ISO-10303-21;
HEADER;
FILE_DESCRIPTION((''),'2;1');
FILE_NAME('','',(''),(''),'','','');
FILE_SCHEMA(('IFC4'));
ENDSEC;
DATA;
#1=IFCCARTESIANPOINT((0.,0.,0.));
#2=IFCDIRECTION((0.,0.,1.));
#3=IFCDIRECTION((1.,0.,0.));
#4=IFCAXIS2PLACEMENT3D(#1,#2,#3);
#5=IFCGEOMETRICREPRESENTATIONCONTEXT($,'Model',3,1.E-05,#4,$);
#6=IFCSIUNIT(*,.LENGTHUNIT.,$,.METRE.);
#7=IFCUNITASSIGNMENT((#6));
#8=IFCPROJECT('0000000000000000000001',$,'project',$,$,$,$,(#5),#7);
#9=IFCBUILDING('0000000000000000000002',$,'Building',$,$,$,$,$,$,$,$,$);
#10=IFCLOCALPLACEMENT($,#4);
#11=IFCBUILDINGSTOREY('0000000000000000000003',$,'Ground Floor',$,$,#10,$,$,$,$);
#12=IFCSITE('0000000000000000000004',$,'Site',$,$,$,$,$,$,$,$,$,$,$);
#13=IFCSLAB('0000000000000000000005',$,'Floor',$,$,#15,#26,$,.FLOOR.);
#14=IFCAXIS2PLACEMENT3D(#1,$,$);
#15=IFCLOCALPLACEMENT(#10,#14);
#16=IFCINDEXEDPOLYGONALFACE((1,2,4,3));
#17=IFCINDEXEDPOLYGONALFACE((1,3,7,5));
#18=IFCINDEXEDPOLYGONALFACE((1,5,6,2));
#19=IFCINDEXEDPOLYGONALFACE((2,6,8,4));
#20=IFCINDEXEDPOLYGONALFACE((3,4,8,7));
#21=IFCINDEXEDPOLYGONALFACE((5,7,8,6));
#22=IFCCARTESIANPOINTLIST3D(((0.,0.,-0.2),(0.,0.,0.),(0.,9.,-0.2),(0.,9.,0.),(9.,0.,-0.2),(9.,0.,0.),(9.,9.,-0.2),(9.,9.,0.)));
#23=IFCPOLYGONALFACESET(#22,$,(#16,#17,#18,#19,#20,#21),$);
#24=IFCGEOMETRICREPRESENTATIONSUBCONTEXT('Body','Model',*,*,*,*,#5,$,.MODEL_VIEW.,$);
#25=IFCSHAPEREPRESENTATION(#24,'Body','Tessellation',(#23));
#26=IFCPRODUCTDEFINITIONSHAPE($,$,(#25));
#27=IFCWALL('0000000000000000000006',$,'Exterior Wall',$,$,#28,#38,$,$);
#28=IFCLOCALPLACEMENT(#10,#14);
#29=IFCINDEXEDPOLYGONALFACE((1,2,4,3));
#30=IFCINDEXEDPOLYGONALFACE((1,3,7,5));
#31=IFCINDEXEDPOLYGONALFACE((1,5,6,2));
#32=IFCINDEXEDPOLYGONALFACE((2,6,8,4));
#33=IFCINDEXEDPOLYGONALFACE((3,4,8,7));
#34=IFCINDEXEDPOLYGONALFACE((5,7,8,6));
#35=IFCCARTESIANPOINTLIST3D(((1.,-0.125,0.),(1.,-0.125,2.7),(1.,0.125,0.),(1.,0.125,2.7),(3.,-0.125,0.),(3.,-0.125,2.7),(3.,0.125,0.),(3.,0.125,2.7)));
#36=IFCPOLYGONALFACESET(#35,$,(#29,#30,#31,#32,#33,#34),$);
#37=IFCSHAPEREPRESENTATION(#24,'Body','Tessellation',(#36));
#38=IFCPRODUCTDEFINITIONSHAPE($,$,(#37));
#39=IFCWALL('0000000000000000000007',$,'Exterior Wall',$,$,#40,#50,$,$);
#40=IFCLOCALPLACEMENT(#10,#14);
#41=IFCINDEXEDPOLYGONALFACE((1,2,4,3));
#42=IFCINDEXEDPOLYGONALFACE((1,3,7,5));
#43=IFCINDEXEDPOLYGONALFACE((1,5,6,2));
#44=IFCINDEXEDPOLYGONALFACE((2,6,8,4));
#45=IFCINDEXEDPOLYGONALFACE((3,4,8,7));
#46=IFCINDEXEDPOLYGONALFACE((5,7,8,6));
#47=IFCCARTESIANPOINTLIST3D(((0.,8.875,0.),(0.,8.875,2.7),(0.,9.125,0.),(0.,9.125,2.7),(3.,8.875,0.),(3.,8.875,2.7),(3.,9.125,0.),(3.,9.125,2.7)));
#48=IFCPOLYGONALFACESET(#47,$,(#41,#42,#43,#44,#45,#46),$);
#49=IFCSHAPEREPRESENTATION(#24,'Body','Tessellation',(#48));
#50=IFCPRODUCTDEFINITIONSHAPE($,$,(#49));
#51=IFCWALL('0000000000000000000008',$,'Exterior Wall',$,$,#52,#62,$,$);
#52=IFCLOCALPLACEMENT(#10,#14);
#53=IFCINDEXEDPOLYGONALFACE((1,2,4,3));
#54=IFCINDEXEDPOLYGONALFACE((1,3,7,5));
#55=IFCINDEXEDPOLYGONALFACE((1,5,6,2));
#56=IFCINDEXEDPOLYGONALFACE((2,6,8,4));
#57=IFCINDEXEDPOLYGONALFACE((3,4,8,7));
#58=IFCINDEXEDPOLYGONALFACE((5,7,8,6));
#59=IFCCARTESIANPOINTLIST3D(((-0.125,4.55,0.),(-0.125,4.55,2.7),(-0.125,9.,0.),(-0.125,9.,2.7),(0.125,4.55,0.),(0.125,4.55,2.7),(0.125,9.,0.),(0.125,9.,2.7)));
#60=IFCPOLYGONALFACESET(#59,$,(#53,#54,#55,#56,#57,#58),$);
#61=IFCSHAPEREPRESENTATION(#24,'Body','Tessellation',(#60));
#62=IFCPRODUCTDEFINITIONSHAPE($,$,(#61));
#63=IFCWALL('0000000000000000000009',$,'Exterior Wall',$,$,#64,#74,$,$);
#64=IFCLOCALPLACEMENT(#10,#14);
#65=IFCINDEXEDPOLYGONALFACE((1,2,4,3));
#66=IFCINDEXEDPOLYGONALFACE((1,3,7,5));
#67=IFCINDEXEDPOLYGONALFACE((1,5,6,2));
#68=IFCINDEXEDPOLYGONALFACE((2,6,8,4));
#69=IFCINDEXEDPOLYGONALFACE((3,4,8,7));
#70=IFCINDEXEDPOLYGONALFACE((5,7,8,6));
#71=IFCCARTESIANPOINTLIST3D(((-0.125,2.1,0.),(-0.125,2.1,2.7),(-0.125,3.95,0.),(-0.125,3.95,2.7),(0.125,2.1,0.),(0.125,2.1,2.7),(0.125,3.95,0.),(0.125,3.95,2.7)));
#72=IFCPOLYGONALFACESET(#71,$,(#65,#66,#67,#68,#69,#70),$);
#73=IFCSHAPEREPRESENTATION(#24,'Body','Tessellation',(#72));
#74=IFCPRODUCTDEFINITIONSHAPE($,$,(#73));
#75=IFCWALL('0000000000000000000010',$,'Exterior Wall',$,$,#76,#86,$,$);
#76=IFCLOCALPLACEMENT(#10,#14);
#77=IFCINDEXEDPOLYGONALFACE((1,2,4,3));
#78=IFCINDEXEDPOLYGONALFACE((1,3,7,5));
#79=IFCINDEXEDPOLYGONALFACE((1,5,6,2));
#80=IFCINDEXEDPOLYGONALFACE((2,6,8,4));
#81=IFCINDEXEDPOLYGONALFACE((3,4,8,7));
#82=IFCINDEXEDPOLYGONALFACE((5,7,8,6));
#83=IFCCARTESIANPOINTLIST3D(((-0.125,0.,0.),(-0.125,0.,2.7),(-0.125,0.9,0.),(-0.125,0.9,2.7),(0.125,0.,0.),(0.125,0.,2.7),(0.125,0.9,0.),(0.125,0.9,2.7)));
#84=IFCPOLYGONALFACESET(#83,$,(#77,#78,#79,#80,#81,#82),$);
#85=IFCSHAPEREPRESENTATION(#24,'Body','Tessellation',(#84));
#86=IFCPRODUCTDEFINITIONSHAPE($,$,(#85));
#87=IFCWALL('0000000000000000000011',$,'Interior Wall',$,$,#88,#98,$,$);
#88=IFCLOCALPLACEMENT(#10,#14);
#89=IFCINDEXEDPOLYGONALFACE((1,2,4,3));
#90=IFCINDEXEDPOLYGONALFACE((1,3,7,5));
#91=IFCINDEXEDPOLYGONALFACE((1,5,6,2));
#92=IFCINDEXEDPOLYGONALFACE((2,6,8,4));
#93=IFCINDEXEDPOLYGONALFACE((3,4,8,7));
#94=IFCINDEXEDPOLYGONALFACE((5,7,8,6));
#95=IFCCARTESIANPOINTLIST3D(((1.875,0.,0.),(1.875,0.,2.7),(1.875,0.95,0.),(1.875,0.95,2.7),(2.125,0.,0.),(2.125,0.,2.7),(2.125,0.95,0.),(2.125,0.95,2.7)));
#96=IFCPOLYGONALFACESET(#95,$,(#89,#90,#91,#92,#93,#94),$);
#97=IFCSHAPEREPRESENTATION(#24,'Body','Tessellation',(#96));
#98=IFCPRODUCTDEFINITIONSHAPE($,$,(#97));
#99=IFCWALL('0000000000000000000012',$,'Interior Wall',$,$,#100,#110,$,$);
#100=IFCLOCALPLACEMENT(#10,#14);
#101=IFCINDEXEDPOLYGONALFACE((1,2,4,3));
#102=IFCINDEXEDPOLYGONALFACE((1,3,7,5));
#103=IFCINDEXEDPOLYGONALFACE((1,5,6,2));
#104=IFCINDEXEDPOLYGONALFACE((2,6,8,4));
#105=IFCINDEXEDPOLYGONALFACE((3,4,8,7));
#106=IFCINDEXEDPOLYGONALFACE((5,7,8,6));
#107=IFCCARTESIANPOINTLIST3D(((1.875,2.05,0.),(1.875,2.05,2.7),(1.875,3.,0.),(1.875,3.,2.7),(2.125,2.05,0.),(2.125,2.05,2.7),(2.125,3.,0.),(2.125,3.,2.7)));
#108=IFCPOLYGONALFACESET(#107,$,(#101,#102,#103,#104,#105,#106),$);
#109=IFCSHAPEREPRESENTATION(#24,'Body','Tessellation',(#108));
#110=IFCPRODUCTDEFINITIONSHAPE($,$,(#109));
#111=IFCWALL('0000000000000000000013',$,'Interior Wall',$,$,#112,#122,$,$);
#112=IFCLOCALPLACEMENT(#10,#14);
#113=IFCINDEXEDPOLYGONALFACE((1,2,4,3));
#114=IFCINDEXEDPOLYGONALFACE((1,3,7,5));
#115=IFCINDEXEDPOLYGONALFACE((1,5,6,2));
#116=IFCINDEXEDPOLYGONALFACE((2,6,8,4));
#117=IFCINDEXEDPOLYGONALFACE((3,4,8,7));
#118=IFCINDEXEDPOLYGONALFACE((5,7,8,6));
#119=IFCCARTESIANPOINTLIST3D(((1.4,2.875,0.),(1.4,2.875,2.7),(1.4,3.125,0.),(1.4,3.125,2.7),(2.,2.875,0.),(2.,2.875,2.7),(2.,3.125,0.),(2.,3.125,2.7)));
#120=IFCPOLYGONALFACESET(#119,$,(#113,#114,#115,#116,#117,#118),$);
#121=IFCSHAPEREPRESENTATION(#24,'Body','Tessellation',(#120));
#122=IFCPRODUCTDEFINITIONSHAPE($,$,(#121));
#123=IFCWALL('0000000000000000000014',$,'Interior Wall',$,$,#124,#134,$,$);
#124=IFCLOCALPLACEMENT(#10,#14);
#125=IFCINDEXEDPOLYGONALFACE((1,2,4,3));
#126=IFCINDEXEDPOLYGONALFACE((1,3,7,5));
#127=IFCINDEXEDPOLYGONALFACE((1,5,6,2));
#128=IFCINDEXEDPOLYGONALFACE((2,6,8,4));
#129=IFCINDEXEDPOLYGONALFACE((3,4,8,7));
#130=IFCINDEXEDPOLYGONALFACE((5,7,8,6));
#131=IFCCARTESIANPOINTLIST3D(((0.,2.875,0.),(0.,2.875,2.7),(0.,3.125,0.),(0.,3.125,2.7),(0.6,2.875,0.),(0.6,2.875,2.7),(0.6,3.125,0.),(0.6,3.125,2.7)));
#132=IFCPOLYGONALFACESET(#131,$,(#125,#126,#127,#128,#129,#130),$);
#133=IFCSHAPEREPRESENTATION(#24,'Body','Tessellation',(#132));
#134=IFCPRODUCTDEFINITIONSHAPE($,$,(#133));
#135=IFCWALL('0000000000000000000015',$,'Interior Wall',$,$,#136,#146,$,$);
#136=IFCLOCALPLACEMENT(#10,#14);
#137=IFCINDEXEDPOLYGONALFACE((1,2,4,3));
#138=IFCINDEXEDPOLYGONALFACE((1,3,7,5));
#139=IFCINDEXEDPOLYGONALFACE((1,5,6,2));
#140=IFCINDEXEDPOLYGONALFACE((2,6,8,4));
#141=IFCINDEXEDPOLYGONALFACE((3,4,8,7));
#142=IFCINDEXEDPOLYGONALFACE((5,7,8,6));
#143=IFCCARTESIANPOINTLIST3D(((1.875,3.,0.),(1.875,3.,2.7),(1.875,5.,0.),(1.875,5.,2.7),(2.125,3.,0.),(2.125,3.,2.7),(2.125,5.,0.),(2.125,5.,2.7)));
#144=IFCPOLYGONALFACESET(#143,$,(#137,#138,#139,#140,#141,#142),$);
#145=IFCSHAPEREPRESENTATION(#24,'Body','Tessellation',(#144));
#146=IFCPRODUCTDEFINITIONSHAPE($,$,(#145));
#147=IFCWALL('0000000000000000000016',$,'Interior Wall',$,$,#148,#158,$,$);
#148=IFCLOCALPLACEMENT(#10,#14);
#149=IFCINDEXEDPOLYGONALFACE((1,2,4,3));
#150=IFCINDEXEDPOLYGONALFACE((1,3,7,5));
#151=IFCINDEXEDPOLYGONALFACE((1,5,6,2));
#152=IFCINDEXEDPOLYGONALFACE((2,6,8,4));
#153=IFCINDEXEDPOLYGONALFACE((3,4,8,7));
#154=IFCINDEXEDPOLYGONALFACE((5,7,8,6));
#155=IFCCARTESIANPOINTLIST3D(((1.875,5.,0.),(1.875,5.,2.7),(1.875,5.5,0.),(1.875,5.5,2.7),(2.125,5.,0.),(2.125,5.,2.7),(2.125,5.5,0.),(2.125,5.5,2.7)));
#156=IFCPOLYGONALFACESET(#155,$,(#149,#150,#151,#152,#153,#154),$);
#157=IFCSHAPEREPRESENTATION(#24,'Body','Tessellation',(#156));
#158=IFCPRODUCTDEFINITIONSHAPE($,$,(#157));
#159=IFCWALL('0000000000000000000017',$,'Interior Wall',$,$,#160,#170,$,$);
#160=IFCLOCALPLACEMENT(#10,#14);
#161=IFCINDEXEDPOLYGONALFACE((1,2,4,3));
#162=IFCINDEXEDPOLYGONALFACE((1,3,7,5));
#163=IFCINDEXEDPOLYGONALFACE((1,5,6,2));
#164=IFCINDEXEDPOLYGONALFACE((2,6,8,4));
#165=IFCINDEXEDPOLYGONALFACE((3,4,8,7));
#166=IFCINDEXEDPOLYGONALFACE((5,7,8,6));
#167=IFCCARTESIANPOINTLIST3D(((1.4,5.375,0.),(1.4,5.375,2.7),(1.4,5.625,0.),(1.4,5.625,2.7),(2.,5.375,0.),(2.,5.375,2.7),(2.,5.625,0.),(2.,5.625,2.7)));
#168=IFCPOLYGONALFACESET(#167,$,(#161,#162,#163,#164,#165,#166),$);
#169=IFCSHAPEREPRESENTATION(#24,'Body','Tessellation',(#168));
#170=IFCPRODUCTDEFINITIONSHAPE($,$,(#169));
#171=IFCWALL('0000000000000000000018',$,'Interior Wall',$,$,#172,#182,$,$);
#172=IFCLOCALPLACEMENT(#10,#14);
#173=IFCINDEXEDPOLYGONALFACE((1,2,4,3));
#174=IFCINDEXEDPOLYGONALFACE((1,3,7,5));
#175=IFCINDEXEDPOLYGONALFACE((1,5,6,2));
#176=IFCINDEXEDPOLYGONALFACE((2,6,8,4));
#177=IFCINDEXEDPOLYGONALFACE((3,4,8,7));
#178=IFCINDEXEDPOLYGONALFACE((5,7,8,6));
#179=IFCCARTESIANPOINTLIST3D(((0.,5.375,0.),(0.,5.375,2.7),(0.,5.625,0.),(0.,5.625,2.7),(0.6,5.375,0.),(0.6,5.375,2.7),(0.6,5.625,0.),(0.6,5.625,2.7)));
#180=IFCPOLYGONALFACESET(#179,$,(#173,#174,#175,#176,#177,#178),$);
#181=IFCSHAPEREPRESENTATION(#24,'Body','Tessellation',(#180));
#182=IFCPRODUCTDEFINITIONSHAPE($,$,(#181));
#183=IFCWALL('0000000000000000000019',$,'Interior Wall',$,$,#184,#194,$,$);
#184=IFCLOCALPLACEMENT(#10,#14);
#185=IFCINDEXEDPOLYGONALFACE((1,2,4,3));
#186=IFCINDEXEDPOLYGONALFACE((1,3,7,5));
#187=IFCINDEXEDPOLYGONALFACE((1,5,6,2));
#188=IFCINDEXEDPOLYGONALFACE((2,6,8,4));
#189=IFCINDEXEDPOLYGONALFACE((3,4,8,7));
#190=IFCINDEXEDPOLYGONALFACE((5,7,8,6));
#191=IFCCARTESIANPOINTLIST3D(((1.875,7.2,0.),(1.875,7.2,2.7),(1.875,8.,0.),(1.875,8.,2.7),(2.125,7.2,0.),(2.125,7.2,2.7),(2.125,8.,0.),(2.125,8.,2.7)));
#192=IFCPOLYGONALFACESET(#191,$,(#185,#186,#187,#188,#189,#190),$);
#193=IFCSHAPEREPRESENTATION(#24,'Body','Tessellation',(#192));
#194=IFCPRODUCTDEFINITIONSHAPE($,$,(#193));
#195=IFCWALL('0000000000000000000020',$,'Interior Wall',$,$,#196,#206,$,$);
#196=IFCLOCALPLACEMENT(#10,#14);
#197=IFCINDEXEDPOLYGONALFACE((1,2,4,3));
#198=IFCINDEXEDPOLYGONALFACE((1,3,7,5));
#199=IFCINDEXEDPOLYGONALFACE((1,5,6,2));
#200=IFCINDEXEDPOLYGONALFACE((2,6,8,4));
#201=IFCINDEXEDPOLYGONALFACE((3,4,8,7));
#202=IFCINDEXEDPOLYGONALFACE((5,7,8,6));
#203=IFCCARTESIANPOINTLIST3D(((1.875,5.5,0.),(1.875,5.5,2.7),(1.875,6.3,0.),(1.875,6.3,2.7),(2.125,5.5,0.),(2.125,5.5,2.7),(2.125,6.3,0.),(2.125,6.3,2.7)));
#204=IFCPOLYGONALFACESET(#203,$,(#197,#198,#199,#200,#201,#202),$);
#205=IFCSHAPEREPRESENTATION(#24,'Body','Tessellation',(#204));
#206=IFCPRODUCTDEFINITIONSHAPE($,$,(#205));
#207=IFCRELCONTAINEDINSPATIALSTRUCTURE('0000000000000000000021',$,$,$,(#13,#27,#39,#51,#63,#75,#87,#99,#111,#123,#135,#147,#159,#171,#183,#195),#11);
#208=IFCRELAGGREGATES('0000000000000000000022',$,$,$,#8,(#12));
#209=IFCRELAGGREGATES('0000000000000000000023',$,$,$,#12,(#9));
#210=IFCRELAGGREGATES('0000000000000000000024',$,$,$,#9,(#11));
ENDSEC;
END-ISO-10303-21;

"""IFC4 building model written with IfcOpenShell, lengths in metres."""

from ifc_helpers import new_model, si_unit, frame, origin_with_axes, place, context, subcontext, project, spatial, indexed_curve, outline, extrude, element, save


model = new_model("IFC4")

# Units and contexts
model_context = context("Model", 3, precision=1e-05, world=origin_with_axes())
body_context = subcontext(model_context, "Body", "Model", "MODEL_VIEW")
ifc_project = project(units=[si_unit("LENGTHUNIT", "METRE")], contexts=[model_context])

# Site, building, storey
site = spatial("IfcSite", under=ifc_project, Name="Site")
building = spatial("IfcBuilding", under=site, Name="Building")
storey_placement = place(None, origin_with_axes())
storey = spatial("IfcBuildingStorey", under=building, at=storey_placement, Name="Ground Floor")

# Slab
slab_placement = place(storey_placement, frame((0.0, 0.0, -0.2), z_axis=(0.0, 0.0, 1.0), x_axis=(1.0, 0.0, 0.0)))
element("IfcSlab", 1, at=slab_placement, inside=storey, Name="Floor", PredefinedType="FLOOR", context=body_context, shape_type="SweptSolid", body=[
    extrude(outline(indexed_curve([(0.0, 0.0), (9.0, 0.0), (9.0, 9.0), (0.0, 9.0)])), None, (0.0, 0.0, 1.0), 0.2),
])

# Walls
wall_1_placement = place(storey_placement, frame((1.0, 0.0, 0.0), z_axis=(0.0, 0.0, 1.0), x_axis=(1.0, 0.0, 0.0)))
element("IfcWall", 2, at=wall_1_placement, inside=storey, Name="Exterior Wall", context=body_context, shape_type="SweptSolid", body=[
    extrude(outline(indexed_curve([(0.0, 0.0), (0.0, 0.25), (2.0, 0.25), (2.0, 0.0), (0.0, 0.0)], self_intersect=False)), frame((0.0, -0.125, 0.0), z_axis=(0.0, 0.0, 1.0), x_axis=(1.0, 0.0, 0.0)), (0.0, 0.0, 1.0), 2.7),
])
wall_2_placement = place(storey_placement, frame((3.0, 9.0, 0.0), z_axis=(0.0, 0.0, 1.0), x_axis=(-1.0, 0.0, 0.0)))
element("IfcWall", 3, at=wall_2_placement, inside=storey, Name="Exterior Wall", context=body_context, shape_type="SweptSolid", body=[
    extrude(outline(indexed_curve([(0.0, 0.0), (0.0, 0.25), (3.0, 0.25), (3.0, 0.0), (0.0, 0.0)], self_intersect=False)), frame((0.0, -0.125, 0.0), z_axis=(0.0, 0.0, 1.0), x_axis=(1.0, 0.0, 0.0)), (0.0, 0.0, 1.0), 2.7),
])
wall_3_placement = place(storey_placement, frame((0.0, 9.0, 0.0), z_axis=(0.0, 0.0, 1.0), x_axis=(0.0, -1.0, 0.0)))
element("IfcWall", 4, at=wall_3_placement, inside=storey, Name="Exterior Wall", context=body_context, shape_type="SweptSolid", body=[
    extrude(outline(indexed_curve([(0.0, 0.0), (0.0, 0.25), (4.45, 0.25), (4.45, 0.0), (0.0, 0.0)], self_intersect=False)), frame((0.0, -0.125, 0.0), z_axis=(0.0, 0.0, 1.0), x_axis=(1.0, 0.0, 0.0)), (0.0, 0.0, 1.0), 2.7),
])
wall_4_placement = place(storey_placement, frame((0.0, 3.95, 0.0), z_axis=(0.0, 0.0, 1.0), x_axis=(0.0, -1.0, 0.0)))
element("IfcWall", 5, at=wall_4_placement, inside=storey, Name="Exterior Wall", context=body_context, shape_type="SweptSolid", body=[
    extrude(outline(indexed_curve([(0.0, 0.0), (0.0, 0.25), (1.85, 0.25), (1.85, 0.0), (0.0, 0.0)], self_intersect=False)), frame((0.0, -0.125, 0.0), z_axis=(0.0, 0.0, 1.0), x_axis=(1.0, 0.0, 0.0)), (0.0, 0.0, 1.0), 2.7),
])
wall_5_placement = place(storey_placement, frame((0.0, 0.9, 0.0), z_axis=(0.0, 0.0, 1.0), x_axis=(0.0, -1.0, 0.0)))
element("IfcWall", 6, at=wall_5_placement, inside=storey, Name="Exterior Wall", context=body_context, shape_type="SweptSolid", body=[
    extrude(outline(indexed_curve([(0.0, 0.0), (0.0, 0.25), (0.9, 0.25), (0.9, 0.0), (0.0, 0.0)], self_intersect=False)), frame((0.0, -0.125, 0.0), z_axis=(0.0, 0.0, 1.0), x_axis=(1.0, 0.0, 0.0)), (0.0, 0.0, 1.0), 2.7),
])
wall_6_placement = place(storey_placement, frame((2.0, 0.0, 0.0), z_axis=(0.0, 0.0, 1.0), x_axis=(0.0, 1.0, 0.0)))
element("IfcWall", 7, at=wall_6_placement, inside=storey, Name="Interior Wall", context=body_context, shape_type="SweptSolid", body=[
    extrude(outline(indexed_curve([(0.0, 0.0), (0.0, 0.25), (0.95, 0.25), (0.95, 0.0), (0.0, 0.0)], self_intersect=False)), frame((0.0, -0.125, 0.0), z_axis=(0.0, 0.0, 1.0), x_axis=(1.0, 0.0, 0.0)), (0.0, 0.0, 1.0), 2.7),
])
wall_7_placement = place(storey_placement, frame((2.0, 2.05, 0.0), z_axis=(0.0, 0.0, 1.0), x_axis=(0.0, 1.0, 0.0)))
element("IfcWall", 8, at=wall_7_placement, inside=storey, Name="Interior Wall", context=body_context, shape_type="SweptSolid", body=[
    extrude(outline(indexed_curve([(0.0, 0.0), (0.0, 0.25), (0.95, 0.25), (0.95, 0.0), (0.0, 0.0)], self_intersect=False)), frame((0.0, -0.125, 0.0), z_axis=(0.0, 0.0, 1.0), x_axis=(1.0, 0.0, 0.0)), (0.0, 0.0, 1.0), 2.7),
])
for number, where, z_axis, x_axis, name in (
    (9, (2.0, 3.0, 0.0), (0.0, 0.0, 1.0), (-1.0, 0.0, 0.0), "Interior Wall"),
    (10, (0.6, 3.0, 0.0), (0.0, 0.0, 1.0), (-1.0, 0.0, 0.0), "Interior Wall"),
):
    element("IfcWall", number, at=place(storey_placement, frame(where, z_axis=z_axis, x_axis=x_axis)), inside=storey, Name=name, context=body_context, shape_type="SweptSolid", body=[
        extrude(outline(indexed_curve([(0.0, 0.0), (0.0, 0.25), (0.6, 0.25), (0.6, 0.0), (0.0, 0.0)], self_intersect=False)), frame((0.0, -0.125, 0.0), z_axis=(0.0, 0.0, 1.0), x_axis=(1.0, 0.0, 0.0)), (0.0, 0.0, 1.0), 2.7),
    ])
wall_8_placement = place(storey_placement, frame((2.0, 5.0, 0.0), z_axis=(0.0, 0.0, 1.0), x_axis=(0.0, -1.0, 0.0)))
element("IfcWall", 11, at=wall_8_placement, inside=storey, Name="Interior Wall", context=body_context, shape_type="SweptSolid", body=[
    extrude(outline(indexed_curve([(0.0, 0.0), (0.0, 0.25), (2.0, 0.25), (2.0, 0.0), (0.0, 0.0)], self_intersect=False)), frame((0.0, -0.125, 0.0), z_axis=(0.0, 0.0, 1.0), x_axis=(1.0, 0.0, 0.0)), (0.0, 0.0, 1.0), 2.7),
])
wall_9_placement = place(storey_placement, frame((2.0, 5.0, 0.0), z_axis=(0.0, 0.0, 1.0), x_axis=(0.0, 1.0, 0.0)))
element("IfcWall", 12, at=wall_9_placement, inside=storey, Name="Interior Wall", context=body_context, shape_type="SweptSolid", body=[
    extrude(outline(indexed_curve([(0.0, 0.0), (0.0, 0.25), (0.5, 0.25), (0.5, 0.0), (0.0, 0.0)], self_intersect=False)), frame((0.0, -0.125, 0.0), z_axis=(0.0, 0.0, 1.0), x_axis=(1.0, 0.0, 0.0)), (0.0, 0.0, 1.0), 2.7),
])
for number, where, z_axis, x_axis, name in (
    (13, (2.0, 5.5, 0.0), (0.0, 0.0, 1.0), (-1.0, 0.0, 0.0), "Interior Wall"),
    (14, (0.6, 5.5, 0.0), (0.0, 0.0, 1.0), (-1.0, 0.0, 0.0), "Interior Wall"),
):
    element("IfcWall", number, at=place(storey_placement, frame(where, z_axis=z_axis, x_axis=x_axis)), inside=storey, Name=name, context=body_context, shape_type="SweptSolid", body=[
        extrude(outline(indexed_curve([(0.0, 0.0), (0.0, 0.25), (0.6, 0.25), (0.6, 0.0), (0.0, 0.0)], self_intersect=False)), frame((0.0, -0.125, 0.0), z_axis=(0.0, 0.0, 1.0), x_axis=(1.0, 0.0, 0.0)), (0.0, 0.0, 1.0), 2.7),
    ])
for number, where, z_axis, x_axis, name in (
    (15, (2.0, 8.0, 0.0), (0.0, 0.0, 1.0), (0.0, -1.0, 0.0), "Interior Wall"),
    (16, (2.0, 6.3, 0.0), (0.0, 0.0, 1.0), (0.0, -1.0, 0.0), "Interior Wall"),
):
    element("IfcWall", number, at=place(storey_placement, frame(where, z_axis=z_axis, x_axis=x_axis)), inside=storey, Name=name, context=body_context, shape_type="SweptSolid", body=[
        extrude(outline(indexed_curve([(0.0, 0.0), (0.0, 0.25), (0.8, 0.25), (0.8, 0.0), (0.0, 0.0)], self_intersect=False)), frame((0.0, -0.125, 0.0), z_axis=(0.0, 0.0, 1.0), x_axis=(1.0, 0.0, 0.0)), (0.0, 0.0, 1.0), 2.7),
    ])

save(model, "model.ifc")
